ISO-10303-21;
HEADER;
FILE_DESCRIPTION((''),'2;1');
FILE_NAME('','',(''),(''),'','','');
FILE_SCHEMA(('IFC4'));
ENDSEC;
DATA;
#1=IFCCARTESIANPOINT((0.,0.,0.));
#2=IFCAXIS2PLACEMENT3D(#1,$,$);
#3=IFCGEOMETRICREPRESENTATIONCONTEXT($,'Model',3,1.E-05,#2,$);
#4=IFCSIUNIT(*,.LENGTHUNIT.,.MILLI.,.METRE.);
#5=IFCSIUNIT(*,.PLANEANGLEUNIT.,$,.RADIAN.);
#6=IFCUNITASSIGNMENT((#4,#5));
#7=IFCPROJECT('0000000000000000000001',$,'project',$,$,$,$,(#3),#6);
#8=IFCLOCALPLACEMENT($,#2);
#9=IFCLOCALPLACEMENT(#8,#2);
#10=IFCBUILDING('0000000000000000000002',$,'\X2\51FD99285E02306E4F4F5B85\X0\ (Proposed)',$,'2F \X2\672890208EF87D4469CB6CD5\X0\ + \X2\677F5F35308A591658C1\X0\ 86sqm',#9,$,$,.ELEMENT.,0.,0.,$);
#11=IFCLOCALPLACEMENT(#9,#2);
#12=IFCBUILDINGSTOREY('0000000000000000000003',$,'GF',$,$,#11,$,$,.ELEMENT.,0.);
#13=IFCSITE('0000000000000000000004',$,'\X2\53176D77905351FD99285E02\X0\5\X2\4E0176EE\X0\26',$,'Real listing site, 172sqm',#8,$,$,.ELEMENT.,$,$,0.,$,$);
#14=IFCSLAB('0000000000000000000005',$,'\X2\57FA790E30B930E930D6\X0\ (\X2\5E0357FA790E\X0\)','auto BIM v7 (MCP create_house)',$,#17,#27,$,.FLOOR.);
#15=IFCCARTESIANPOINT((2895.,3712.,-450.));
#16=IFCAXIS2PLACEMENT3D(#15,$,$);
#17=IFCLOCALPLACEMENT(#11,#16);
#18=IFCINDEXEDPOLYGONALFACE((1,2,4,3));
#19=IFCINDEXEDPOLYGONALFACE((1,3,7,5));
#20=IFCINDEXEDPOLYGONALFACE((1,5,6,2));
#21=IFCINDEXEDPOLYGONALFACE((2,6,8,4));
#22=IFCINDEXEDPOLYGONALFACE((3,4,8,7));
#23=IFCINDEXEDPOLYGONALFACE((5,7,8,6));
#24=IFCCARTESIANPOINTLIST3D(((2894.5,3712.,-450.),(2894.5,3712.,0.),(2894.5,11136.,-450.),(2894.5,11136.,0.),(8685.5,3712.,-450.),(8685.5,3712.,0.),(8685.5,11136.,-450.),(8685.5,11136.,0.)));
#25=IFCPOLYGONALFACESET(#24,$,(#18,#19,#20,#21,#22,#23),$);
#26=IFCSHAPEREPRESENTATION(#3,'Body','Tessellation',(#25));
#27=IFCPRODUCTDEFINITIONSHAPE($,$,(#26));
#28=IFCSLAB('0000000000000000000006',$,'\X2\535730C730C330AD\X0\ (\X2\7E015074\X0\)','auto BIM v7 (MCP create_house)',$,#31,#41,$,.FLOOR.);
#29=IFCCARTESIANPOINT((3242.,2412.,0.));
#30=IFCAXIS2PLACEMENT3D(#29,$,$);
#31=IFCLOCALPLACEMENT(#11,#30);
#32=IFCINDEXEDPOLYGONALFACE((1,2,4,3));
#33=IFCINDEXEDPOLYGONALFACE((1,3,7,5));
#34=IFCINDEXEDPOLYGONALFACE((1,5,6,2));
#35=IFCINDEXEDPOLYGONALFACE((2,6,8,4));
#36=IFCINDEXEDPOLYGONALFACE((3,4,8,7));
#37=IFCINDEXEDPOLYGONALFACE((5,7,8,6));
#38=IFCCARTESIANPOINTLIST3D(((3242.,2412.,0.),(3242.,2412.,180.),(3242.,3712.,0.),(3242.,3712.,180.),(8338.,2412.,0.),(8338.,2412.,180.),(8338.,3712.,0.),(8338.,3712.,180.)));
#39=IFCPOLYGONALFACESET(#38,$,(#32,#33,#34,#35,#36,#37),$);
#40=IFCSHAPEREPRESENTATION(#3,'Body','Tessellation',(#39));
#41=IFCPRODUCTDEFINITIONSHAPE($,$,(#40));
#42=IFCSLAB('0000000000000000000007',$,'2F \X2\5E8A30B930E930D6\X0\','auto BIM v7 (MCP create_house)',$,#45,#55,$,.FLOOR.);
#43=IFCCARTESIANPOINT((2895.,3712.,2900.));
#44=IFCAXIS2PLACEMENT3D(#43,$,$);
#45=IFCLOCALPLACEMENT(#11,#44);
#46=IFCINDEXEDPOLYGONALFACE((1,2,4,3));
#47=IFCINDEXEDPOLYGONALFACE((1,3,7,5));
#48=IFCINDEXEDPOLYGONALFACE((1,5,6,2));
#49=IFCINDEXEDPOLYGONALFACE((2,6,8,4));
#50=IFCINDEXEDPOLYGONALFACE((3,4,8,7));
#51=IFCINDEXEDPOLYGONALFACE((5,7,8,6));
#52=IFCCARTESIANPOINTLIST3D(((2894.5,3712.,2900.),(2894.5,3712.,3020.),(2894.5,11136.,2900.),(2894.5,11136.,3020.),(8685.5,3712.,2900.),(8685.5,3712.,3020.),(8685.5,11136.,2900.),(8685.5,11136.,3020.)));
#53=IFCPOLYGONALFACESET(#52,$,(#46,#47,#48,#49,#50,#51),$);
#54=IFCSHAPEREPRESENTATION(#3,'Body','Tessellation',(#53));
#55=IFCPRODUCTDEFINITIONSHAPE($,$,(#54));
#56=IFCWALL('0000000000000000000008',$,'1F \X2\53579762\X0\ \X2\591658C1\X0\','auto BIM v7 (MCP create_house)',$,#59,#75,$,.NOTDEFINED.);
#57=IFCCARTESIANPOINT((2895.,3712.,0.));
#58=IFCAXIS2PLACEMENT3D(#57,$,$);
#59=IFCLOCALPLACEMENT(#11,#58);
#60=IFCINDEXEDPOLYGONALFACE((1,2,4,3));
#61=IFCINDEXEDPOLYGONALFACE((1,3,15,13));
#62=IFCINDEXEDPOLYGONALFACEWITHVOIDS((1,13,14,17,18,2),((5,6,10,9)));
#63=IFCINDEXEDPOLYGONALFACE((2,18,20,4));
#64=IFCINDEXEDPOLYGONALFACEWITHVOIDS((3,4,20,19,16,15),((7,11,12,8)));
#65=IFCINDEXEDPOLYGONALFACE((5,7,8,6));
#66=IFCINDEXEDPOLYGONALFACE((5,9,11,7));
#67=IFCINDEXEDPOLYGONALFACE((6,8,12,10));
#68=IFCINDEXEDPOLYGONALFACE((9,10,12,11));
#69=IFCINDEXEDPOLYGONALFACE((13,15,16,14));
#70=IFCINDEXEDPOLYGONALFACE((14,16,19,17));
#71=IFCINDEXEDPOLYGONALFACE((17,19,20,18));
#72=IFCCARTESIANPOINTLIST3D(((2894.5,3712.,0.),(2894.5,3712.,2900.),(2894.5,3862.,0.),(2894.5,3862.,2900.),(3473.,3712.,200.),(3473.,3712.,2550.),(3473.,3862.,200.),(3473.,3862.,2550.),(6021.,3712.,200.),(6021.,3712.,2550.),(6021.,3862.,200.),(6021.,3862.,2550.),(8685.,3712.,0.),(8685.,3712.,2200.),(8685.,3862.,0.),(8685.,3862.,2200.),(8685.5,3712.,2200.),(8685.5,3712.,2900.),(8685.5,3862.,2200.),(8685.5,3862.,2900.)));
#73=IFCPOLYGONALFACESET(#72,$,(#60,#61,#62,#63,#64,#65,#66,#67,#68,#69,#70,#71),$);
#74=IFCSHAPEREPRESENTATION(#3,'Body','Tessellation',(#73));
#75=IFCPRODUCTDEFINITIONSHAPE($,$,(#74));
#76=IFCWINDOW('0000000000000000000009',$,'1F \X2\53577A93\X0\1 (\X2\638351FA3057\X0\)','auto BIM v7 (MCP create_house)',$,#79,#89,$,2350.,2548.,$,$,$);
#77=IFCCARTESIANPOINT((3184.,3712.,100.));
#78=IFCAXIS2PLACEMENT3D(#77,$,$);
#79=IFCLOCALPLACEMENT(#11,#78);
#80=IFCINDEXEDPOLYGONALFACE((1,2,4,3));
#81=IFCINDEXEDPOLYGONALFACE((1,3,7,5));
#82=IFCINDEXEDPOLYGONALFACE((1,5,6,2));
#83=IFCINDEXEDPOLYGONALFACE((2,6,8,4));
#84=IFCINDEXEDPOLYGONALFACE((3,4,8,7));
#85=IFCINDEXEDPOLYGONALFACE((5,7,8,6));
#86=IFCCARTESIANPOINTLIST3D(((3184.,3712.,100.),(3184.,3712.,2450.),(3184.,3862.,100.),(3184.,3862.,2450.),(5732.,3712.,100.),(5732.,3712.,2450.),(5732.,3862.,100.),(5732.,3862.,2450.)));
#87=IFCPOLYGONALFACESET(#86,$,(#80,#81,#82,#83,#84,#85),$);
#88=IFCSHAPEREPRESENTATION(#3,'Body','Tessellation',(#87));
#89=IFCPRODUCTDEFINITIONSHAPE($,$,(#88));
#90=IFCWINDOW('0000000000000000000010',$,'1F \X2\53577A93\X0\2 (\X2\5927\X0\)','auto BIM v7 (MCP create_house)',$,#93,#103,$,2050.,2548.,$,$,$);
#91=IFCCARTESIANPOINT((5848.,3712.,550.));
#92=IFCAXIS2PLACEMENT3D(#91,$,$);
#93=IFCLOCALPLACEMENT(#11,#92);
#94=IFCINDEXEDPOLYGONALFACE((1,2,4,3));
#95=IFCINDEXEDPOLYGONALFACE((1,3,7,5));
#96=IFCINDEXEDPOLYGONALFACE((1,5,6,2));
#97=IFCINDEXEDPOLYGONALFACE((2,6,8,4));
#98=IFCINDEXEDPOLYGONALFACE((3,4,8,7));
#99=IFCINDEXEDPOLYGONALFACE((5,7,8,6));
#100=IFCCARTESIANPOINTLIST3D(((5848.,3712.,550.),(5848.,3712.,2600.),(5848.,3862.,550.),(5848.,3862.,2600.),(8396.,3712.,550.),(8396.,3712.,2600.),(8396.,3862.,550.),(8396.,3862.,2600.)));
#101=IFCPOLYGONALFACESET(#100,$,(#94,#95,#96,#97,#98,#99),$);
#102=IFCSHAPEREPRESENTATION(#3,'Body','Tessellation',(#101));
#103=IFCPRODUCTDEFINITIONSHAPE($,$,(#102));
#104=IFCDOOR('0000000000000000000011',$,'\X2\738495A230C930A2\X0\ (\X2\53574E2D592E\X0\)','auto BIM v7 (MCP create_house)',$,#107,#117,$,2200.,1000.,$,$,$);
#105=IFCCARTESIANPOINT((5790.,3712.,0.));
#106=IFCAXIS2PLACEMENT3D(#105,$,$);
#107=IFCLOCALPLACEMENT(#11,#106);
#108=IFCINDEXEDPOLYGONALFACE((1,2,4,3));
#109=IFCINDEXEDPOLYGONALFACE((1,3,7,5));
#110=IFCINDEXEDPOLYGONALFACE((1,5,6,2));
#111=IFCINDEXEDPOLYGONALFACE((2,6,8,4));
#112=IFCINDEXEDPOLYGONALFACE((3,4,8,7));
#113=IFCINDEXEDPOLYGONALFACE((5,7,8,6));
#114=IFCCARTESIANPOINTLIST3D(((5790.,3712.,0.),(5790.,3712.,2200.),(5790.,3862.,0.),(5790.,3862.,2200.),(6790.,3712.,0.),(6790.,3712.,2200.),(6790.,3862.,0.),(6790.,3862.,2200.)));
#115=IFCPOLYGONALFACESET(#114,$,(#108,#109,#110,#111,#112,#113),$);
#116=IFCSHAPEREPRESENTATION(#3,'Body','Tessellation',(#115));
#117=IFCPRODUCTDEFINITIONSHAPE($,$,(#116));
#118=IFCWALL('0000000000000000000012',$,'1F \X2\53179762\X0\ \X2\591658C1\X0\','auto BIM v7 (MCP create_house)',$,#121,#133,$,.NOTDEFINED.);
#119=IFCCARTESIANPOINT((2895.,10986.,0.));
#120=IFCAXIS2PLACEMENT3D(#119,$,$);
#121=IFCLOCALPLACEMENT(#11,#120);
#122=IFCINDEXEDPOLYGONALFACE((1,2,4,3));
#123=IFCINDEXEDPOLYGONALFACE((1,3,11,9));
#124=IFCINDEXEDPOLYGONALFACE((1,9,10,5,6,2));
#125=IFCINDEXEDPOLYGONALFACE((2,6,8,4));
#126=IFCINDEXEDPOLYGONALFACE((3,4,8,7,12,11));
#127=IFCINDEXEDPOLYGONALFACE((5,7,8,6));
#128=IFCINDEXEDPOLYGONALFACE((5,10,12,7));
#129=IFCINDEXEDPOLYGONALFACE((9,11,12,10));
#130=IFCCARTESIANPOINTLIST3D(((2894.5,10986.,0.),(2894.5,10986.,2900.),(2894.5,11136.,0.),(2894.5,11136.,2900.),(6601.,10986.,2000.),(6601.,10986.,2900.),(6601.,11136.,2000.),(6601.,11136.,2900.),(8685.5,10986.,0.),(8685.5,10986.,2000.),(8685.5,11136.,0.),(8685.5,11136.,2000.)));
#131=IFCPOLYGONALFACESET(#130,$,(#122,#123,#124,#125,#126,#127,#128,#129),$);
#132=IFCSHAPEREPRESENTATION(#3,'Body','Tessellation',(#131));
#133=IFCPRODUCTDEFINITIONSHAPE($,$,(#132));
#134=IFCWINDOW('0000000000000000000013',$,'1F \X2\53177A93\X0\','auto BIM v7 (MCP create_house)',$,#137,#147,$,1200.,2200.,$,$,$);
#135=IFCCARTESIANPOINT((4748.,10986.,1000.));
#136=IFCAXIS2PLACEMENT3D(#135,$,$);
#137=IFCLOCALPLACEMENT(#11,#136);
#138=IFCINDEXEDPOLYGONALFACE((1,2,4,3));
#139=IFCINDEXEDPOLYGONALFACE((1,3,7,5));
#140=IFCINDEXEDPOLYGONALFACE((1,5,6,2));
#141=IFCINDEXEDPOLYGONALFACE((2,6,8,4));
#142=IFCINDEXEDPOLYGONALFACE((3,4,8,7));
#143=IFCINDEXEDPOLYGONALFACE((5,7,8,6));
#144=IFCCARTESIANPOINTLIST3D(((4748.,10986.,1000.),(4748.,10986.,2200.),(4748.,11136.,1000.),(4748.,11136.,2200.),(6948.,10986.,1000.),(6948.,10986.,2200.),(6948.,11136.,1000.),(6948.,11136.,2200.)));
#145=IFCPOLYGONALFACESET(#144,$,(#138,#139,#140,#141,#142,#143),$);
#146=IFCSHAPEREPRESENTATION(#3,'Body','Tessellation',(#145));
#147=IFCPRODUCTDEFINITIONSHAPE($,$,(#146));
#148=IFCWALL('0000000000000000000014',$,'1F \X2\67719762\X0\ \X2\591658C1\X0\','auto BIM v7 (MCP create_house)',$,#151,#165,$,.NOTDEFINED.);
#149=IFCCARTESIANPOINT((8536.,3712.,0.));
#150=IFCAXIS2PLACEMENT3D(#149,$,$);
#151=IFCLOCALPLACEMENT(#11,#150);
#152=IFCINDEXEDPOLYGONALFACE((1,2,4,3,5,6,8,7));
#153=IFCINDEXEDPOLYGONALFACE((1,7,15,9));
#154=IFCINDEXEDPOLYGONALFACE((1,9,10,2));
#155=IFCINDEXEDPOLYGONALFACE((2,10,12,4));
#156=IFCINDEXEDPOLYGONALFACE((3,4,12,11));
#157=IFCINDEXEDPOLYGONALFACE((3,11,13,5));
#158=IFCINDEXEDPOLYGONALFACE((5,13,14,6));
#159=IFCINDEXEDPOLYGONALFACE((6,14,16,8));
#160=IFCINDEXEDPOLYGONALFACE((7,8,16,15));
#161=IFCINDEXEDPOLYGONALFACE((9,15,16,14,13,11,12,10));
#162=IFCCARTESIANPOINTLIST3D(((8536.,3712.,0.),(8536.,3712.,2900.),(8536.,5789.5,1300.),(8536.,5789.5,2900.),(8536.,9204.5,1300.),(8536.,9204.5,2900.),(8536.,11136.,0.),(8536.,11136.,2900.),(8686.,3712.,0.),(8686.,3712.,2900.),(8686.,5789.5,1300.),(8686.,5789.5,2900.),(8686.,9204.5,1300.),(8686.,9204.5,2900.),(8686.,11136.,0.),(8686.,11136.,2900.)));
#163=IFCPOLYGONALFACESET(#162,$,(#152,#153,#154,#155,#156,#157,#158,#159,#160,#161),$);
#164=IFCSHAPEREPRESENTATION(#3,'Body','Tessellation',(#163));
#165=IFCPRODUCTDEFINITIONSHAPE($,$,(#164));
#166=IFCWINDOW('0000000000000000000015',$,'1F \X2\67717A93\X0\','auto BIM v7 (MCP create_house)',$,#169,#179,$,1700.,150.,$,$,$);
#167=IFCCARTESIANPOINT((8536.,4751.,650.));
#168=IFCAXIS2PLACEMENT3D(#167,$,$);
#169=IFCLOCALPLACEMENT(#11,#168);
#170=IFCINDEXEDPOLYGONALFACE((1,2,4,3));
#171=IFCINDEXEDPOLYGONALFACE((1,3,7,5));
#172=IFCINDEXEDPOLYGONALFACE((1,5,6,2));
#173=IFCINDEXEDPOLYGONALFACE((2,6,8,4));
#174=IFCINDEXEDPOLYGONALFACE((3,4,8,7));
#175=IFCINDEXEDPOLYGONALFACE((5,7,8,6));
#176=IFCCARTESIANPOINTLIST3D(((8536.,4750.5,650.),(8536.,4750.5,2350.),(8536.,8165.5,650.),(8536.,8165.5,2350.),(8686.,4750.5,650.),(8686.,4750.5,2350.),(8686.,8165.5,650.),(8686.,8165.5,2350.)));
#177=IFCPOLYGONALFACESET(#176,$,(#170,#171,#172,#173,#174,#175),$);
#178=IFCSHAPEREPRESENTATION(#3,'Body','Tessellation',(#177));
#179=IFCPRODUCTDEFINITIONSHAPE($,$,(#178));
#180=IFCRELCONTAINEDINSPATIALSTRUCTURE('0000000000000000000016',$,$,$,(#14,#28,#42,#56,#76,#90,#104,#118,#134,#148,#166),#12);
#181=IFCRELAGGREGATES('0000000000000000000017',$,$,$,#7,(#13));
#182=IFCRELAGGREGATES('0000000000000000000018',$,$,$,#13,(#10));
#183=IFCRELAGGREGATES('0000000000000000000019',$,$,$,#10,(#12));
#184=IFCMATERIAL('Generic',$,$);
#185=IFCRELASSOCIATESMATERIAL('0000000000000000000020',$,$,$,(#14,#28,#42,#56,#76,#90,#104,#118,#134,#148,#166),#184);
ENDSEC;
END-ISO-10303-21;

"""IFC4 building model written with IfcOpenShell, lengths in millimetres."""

from ifc_helpers import new_model, si_unit, frame, frame_2d, origin, place, context, project, spatial, rectangle, extrude, material, element, fill, save


model = new_model("IFC4")

# Units and contexts
model_context = context("Model", 3, precision=1e-05, world=origin())
ifc_project = project(units=[si_unit("LENGTHUNIT", "METRE", prefix="MILLI"), si_unit("PLANEANGLEUNIT", "RADIAN")], contexts=[model_context])

# Site, building, storey
site_placement = place(None, origin())
site = spatial("IfcSite", under=ifc_project, at=site_placement, Name="北海道函館市5丁目26", ObjectType="Real listing site, 172sqm", CompositionType="ELEMENT", RefElevation=0.0)
building_placement = place(site_placement, origin())
building = spatial("IfcBuilding", under=site, at=building_placement, Name="函館市の住宅 (Proposed)", ObjectType="2F 木造軸組構法 + 板張り外壁 86sqm", CompositionType="ELEMENT", ElevationOfRefHeight=0.0, ElevationOfTerrain=0.0)
storey_placement = place(building_placement, origin())
storey = spatial("IfcBuildingStorey", under=building, at=storey_placement, Name="GF", CompositionType="ELEMENT", Elevation=0.0)

# Slabs
ifc_material = material(Name="Generic")
slab_1_placement = place(storey_placement, frame((2895.0, 3712.0, -450.0)))
element("IfcSlab", 1, at=slab_1_placement, inside=storey, material=ifc_material, Name="基礎スラブ (布基礎)", Description="auto BIM v7 (MCP create_house)", PredefinedType="FLOOR", context=model_context, shape_type="SweptSolid", body=[
    extrude(rectangle(XDim=5791.0, YDim=7424.0, at=frame_2d((2895.0, 3712.0))), frame((2895.0, 3712.0, -450.0)), (0.0, 0.0, 1.0), 450.0),
])
slab_2_placement = place(storey_placement, frame((3242.0, 2412.0, 0.0)))
element("IfcSlab", 2, at=slab_2_placement, inside=storey, material=ifc_material, Name="南デッキ (縁側)", Description="auto BIM v7 (MCP create_house)", PredefinedType="FLOOR", context=model_context, shape_type="SweptSolid", body=[
    extrude(rectangle(XDim=5096.0, YDim=1300.0, at=frame_2d((2548.0, 650.0))), frame((3242.0, 2412.0, 0.0)), (0.0, 0.0, 1.0), 180.0),
])
slab_3_placement = place(storey_placement, frame((2895.0, 3712.0, 2900.0)))
element("IfcSlab", 3, at=slab_3_placement, inside=storey, material=ifc_material, Name="2F 床スラブ", Description="auto BIM v7 (MCP create_house)", PredefinedType="FLOOR", context=model_context, shape_type="SweptSolid", body=[
    extrude(rectangle(XDim=5791.0, YDim=7424.0, at=frame_2d((2895.0, 3712.0))), frame((2895.0, 3712.0, 2900.0)), (0.0, 0.0, 1.0), 120.0),
])

# Wall, openings, windows, door
wall_1_placement = place(storey_placement, frame((2895.0, 3712.0, 0.0)))
wall_1 = element("IfcWall", 4, at=wall_1_placement, inside=storey, material=ifc_material, Name="1F 南面 外壁", Description="auto BIM v7 (MCP create_house)", PredefinedType="NOTDEFINED", context=model_context, shape_type="SweptSolid", body=[
    extrude(rectangle(XDim=5791.0, YDim=150.0, at=frame_2d((2895.0, 75.0))), frame((2895.0, 3712.0, 0.0)), (0.0, 0.0, 1.0), 2900.0),
])
opening_1_placement = place(storey_placement, frame((3184.0, 3712.0, 100.0)))
opening_1 = element("IfcOpeningElement", 5, at=opening_1_placement, cuts=wall_1, PredefinedType="NOTDEFINED", context=model_context, shape_type="SweptSolid", body=[
    extrude(rectangle(XDim=2548.0, YDim=150.0, at=frame_2d((1274.0, 75.0))), frame((3184.0, 3712.0, 100.0)), (0.0, 0.0, 1.0), 2350.0),
])
opening_2_placement = place(storey_placement, frame((5848.0, 3712.0, 550.0)))
opening_2 = element("IfcOpeningElement", 6, at=opening_2_placement, cuts=wall_1, PredefinedType="NOTDEFINED", context=model_context, shape_type="SweptSolid", body=[
    extrude(rectangle(XDim=2548.0, YDim=150.0, at=frame_2d((1274.0, 75.0))), frame((5848.0, 3712.0, 550.0)), (0.0, 0.0, 1.0), 2050.0),
])
opening_3_placement = place(storey_placement, frame((5790.0, 3712.0, 0.0)))
opening_3 = element("IfcOpeningElement", 7, at=opening_3_placement, cuts=wall_1, PredefinedType="NOTDEFINED", context=model_context, shape_type="SweptSolid", body=[
    extrude(rectangle(XDim=1000.0, YDim=150.0, at=frame_2d((500.0, 75.0))), frame((5790.0, 3712.0, 0.0)), (0.0, 0.0, 1.0), 2200.0),
])
window_1_placement = place(storey_placement, frame((3184.0, 3712.0, 100.0)))
window_1 = element("IfcWindow", 8, at=window_1_placement, inside=storey, material=ifc_material, Name="1F 南窓1 (掃出し)", Description="auto BIM v7 (MCP create_house)", OverallHeight=2350.0, OverallWidth=2548.0, context=model_context, shape_type="SweptSolid", body=[
    extrude(rectangle(XDim=2548.0, YDim=150.0, at=frame_2d((1274.0, 75.0))), frame((3184.0, 3712.0, 100.0)), (0.0, 0.0, 1.0), 2350.0),
])
fill(opening_1, window_1)
window_2_placement = place(storey_placement, frame((5848.0, 3712.0, 550.0)))
window_2 = element("IfcWindow", 9, at=window_2_placement, inside=storey, material=ifc_material, Name="1F 南窓2 (大)", Description="auto BIM v7 (MCP create_house)", OverallHeight=2050.0, OverallWidth=2548.0, context=model_context, shape_type="SweptSolid", body=[
    extrude(rectangle(XDim=2548.0, YDim=150.0, at=frame_2d((1274.0, 75.0))), frame((5848.0, 3712.0, 550.0)), (0.0, 0.0, 1.0), 2050.0),
])
fill(opening_2, window_2)
door_placement = place(storey_placement, frame((5790.0, 3712.0, 0.0)))
door = element("IfcDoor", 10, at=door_placement, inside=storey, material=ifc_material, Name="玄関ドア (南中央)", Description="auto BIM v7 (MCP create_house)", OverallHeight=2200.0, OverallWidth=1000.0, context=model_context, shape_type="SweptSolid", body=[
    extrude(rectangle(XDim=1000.0, YDim=150.0, at=frame_2d((500.0, 75.0))), frame((5790.0, 3712.0, 0.0)), (0.0, 0.0, 1.0), 2200.0),
])
fill(opening_3, door)

# Walls, openings, windows
wall_2_placement = place(storey_placement, frame((2895.0, 10986.0, 0.0)))
wall_2 = element("IfcWall", 11, at=wall_2_placement, inside=storey, material=ifc_material, Name="1F 北面 外壁", Description="auto BIM v7 (MCP create_house)", PredefinedType="NOTDEFINED", context=model_context, shape_type="SweptSolid", body=[
    extrude(rectangle(XDim=5791.0, YDim=150.0, at=frame_2d((2895.0, 75.0))), frame((2895.0, 10986.0, 0.0)), (0.0, 0.0, 1.0), 2900.0),
])
opening_4_placement = place(storey_placement, frame((4748.0, 10986.0, 1000.0)))
opening_4 = element("IfcOpeningElement", 12, at=opening_4_placement, cuts=wall_2, PredefinedType="NOTDEFINED", context=model_context, shape_type="SweptSolid", body=[
    extrude(rectangle(XDim=2200.0, YDim=150.0, at=frame_2d((1100.0, 75.0))), frame((4748.0, 10986.0, 1000.0)), (0.0, 0.0, 1.0), 1200.0),
])
window_3_placement = place(storey_placement, frame((4748.0, 10986.0, 1000.0)))
window_3 = element("IfcWindow", 13, at=window_3_placement, inside=storey, material=ifc_material, Name="1F 北窓", Description="auto BIM v7 (MCP create_house)", OverallHeight=1200.0, OverallWidth=2200.0, context=model_context, shape_type="SweptSolid", body=[
    extrude(rectangle(XDim=2200.0, YDim=150.0, at=frame_2d((1100.0, 75.0))), frame((4748.0, 10986.0, 1000.0)), (0.0, 0.0, 1.0), 1200.0),
])
fill(opening_4, window_3)
wall_3_placement = place(storey_placement, frame((8536.0, 3712.0, 0.0)))
wall_3 = element("IfcWall", 14, at=wall_3_placement, inside=storey, material=ifc_material, Name="1F 東面 外壁", Description="auto BIM v7 (MCP create_house)", PredefinedType="NOTDEFINED", context=model_context, shape_type="SweptSolid", body=[
    extrude(rectangle(XDim=150.0, YDim=7424.0, at=frame_2d((75.0, 3712.0))), frame((8536.0, 3712.0, 0.0)), (0.0, 0.0, 1.0), 2900.0),
])
opening_5_placement = place(storey_placement, frame((8536.0, 4751.0, 650.0)))
opening_5 = element("IfcOpeningElement", 15, at=opening_5_placement, cuts=wall_3, PredefinedType="NOTDEFINED", context=model_context, shape_type="SweptSolid", body=[
    extrude(rectangle(XDim=150.0, YDim=3415.0, at=frame_2d((75.0, 1707.0))), frame((8536.0, 4751.0, 650.0)), (0.0, 0.0, 1.0), 1700.0),
])
window_4_placement = place(storey_placement, frame((8536.0, 4751.0, 650.0)))
window_4 = element("IfcWindow", 16, at=window_4_placement, inside=storey, material=ifc_material, Name="1F 東窓", Description="auto BIM v7 (MCP create_house)", OverallHeight=1700.0, OverallWidth=150.0, context=model_context, shape_type="SweptSolid", body=[
    extrude(rectangle(XDim=150.0, YDim=3415.0, at=frame_2d((75.0, 1707.0))), frame((8536.0, 4751.0, 650.0)), (0.0, 0.0, 1.0), 1700.0),
])
fill(opening_5, window_4)

save(model, "model.ifc")
